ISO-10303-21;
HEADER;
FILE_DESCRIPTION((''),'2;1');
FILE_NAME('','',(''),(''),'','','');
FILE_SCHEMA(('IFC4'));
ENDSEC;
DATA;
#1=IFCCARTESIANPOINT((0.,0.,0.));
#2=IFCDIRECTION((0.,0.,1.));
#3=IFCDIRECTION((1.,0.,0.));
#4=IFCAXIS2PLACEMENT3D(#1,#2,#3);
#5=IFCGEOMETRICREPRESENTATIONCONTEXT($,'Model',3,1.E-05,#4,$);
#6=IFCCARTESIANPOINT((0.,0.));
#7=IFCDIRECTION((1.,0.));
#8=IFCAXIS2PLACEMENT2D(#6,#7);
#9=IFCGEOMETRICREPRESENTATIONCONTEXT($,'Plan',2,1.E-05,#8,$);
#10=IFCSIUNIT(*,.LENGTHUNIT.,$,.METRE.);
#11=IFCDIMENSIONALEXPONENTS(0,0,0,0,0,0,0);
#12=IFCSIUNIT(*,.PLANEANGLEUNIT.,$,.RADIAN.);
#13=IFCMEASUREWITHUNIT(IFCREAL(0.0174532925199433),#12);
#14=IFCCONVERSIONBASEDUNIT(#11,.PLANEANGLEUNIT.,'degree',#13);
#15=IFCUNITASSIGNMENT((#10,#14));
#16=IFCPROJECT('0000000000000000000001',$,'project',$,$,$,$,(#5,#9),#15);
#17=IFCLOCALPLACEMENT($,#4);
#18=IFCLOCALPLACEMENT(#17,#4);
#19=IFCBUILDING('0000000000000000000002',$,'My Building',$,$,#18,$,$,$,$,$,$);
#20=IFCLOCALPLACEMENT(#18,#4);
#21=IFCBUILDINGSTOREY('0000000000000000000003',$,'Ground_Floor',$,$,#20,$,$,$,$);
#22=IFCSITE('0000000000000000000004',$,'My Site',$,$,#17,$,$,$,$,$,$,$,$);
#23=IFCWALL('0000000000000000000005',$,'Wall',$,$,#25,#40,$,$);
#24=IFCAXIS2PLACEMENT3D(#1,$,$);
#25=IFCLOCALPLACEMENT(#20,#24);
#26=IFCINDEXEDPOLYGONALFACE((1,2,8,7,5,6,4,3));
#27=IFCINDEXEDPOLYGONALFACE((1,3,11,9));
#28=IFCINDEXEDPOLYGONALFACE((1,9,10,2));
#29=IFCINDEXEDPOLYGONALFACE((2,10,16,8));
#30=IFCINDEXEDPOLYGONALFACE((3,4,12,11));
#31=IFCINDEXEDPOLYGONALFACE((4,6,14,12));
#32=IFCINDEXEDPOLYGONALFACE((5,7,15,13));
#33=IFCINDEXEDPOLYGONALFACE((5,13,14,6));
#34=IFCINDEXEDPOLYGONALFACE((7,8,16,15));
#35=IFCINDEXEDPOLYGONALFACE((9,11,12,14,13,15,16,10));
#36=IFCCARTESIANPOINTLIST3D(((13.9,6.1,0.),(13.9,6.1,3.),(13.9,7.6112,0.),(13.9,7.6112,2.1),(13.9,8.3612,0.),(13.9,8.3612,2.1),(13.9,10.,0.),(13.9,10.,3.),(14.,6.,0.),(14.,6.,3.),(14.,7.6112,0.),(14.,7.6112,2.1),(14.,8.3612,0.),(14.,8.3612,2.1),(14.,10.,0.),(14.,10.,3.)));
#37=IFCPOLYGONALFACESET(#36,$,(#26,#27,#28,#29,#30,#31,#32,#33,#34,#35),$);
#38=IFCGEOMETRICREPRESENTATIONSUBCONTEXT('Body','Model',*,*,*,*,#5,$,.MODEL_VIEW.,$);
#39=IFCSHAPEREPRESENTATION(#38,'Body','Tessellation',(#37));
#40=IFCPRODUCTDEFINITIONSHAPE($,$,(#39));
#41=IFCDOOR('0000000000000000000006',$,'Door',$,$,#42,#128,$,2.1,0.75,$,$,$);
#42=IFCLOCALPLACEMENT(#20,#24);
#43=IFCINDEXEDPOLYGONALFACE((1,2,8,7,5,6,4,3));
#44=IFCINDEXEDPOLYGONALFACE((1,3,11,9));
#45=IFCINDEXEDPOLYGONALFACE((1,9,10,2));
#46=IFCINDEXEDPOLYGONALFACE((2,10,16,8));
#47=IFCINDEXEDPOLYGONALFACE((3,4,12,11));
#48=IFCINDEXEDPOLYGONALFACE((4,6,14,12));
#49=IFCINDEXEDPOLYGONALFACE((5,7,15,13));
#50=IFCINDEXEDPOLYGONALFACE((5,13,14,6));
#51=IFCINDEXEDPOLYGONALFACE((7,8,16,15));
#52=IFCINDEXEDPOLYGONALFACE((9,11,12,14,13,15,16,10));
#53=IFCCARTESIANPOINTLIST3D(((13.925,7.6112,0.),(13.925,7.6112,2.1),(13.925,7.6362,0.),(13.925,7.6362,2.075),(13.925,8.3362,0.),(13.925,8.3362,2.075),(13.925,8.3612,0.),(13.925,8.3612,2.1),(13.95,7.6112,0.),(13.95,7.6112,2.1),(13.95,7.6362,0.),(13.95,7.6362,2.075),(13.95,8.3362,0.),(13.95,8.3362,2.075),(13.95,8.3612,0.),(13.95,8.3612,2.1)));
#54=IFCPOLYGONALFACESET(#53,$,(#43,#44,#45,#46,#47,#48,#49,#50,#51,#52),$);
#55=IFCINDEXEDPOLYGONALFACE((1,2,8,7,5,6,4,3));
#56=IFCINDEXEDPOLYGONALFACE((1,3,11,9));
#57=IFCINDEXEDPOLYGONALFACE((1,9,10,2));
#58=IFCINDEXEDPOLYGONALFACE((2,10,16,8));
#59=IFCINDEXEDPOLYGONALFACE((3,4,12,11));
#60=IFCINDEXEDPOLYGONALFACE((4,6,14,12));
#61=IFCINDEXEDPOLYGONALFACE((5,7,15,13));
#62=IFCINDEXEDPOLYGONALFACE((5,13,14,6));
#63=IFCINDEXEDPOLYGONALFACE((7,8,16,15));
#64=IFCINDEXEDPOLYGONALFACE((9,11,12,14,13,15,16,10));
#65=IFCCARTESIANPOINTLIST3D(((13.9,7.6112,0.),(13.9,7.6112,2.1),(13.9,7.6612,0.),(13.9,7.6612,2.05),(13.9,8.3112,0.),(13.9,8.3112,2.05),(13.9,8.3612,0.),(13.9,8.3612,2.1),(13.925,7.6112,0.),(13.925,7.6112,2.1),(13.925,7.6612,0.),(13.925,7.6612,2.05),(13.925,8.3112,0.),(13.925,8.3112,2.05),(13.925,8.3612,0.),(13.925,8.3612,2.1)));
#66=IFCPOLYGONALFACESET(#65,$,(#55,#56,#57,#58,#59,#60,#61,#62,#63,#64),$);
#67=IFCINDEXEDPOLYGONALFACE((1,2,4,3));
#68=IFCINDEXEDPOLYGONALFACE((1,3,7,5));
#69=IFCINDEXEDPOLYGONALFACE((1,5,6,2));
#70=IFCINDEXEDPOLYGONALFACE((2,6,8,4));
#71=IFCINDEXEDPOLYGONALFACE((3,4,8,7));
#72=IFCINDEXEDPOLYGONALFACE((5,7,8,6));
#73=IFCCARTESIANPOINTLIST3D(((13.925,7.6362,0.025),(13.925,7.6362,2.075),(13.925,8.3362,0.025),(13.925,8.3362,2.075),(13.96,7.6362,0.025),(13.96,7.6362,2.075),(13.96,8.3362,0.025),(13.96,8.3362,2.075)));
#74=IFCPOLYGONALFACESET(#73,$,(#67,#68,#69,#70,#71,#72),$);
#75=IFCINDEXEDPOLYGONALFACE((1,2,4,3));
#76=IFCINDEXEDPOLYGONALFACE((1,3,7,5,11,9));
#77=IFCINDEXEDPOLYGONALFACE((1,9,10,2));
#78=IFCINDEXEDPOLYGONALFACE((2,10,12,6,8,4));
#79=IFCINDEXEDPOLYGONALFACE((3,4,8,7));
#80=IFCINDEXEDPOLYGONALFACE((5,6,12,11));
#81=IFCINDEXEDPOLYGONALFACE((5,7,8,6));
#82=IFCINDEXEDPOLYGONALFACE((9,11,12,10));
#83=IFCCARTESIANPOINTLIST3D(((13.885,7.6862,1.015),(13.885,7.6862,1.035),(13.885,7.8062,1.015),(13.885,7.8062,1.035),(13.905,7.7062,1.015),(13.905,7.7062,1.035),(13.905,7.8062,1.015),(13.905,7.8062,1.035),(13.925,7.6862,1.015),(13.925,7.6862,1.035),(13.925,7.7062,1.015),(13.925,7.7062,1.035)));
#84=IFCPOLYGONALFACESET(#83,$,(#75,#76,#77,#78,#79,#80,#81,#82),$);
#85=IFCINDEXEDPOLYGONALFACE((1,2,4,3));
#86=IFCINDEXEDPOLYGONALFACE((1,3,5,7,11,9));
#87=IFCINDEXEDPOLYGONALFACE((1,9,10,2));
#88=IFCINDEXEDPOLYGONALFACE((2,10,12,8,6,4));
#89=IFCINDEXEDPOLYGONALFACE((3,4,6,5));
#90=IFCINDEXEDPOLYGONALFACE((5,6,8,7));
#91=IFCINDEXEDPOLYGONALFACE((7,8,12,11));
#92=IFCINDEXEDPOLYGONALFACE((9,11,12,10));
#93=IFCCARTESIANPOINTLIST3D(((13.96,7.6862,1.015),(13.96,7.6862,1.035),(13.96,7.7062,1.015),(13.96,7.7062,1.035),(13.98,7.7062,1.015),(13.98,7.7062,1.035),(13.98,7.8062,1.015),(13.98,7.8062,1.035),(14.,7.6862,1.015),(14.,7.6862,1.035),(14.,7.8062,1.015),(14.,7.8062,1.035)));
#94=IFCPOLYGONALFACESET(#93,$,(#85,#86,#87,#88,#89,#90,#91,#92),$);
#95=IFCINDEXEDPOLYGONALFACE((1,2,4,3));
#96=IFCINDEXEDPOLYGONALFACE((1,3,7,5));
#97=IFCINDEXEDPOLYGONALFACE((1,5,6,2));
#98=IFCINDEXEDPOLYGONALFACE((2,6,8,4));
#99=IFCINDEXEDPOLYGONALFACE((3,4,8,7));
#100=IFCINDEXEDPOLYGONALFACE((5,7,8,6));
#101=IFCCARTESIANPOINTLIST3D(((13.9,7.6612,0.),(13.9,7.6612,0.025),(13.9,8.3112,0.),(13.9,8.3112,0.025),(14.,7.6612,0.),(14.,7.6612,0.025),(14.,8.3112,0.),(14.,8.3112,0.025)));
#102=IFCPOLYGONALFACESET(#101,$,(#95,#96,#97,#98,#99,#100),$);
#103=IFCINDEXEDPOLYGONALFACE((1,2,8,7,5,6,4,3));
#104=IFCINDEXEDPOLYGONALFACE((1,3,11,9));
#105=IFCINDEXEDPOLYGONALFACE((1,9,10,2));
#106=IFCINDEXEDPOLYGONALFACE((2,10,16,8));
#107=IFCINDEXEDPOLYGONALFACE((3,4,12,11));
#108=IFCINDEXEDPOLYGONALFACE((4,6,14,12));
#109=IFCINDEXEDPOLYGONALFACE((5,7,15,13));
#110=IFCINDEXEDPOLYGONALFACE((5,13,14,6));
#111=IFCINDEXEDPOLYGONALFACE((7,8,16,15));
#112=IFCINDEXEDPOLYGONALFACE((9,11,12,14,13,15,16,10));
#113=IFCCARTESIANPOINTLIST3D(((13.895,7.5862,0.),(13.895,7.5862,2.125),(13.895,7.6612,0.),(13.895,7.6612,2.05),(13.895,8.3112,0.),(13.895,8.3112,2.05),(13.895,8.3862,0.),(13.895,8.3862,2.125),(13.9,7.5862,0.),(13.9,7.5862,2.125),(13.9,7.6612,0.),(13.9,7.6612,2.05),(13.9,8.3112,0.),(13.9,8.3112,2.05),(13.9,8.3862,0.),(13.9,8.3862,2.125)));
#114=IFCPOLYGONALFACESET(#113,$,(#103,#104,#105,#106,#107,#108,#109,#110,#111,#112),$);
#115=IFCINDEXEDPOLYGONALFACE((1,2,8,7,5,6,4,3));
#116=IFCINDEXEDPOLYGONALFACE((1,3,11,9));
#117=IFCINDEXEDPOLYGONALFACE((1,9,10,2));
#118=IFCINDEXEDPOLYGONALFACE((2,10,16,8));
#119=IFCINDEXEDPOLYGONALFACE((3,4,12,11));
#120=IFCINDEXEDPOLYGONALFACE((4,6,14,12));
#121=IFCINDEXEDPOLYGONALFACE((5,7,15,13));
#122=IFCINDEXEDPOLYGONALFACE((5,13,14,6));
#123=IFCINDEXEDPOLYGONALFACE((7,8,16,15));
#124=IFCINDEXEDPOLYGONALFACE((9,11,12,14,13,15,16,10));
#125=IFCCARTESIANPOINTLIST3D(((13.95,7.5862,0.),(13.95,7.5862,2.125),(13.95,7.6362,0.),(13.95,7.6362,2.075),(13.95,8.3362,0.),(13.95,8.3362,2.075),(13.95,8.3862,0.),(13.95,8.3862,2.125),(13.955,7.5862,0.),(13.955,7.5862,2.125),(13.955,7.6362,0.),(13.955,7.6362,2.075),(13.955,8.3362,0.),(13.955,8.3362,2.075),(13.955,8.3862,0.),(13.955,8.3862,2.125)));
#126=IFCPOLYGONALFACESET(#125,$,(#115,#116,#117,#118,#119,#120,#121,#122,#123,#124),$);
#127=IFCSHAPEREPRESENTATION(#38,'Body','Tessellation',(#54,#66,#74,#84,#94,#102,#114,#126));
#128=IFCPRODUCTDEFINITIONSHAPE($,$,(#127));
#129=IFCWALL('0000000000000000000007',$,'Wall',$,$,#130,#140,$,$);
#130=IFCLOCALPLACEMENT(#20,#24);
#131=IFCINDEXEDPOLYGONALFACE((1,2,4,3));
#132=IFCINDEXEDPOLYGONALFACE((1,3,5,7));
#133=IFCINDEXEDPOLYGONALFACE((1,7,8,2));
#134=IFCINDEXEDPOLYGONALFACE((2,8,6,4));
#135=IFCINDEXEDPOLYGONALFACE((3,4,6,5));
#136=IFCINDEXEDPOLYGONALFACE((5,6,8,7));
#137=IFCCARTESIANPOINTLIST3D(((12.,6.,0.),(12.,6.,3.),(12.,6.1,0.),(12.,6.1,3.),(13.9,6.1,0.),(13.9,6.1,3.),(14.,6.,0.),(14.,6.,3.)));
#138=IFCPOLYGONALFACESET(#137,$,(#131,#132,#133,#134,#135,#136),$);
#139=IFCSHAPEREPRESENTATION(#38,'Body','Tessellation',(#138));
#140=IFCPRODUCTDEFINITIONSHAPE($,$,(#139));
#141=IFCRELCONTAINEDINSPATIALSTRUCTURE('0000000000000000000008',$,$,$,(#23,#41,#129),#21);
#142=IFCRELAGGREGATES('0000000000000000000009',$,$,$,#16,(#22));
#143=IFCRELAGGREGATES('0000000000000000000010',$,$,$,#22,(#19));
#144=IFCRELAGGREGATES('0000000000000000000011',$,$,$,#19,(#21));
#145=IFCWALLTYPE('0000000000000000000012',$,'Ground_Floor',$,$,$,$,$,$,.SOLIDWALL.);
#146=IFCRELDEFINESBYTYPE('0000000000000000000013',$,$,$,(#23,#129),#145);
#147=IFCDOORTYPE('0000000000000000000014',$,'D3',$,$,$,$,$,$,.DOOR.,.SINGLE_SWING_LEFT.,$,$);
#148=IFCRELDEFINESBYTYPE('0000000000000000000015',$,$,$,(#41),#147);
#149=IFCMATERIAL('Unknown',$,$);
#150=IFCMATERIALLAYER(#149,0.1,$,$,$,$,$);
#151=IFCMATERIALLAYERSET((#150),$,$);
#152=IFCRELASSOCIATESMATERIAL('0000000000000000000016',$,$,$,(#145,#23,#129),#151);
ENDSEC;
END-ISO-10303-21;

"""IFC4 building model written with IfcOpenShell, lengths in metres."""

from ifc_helpers import new_model, entity, si_unit, converted_unit, frame, origin_with_axes, origin_2d_with_axis, place, context, subcontext, project, spatial, line, indexed_curve, outline, extrude, shape, source, transform, mapped, material, layer, layer_set, layer_usage, type_object, type_shapes, element, fill, save


model = new_model("IFC4")

# Units and contexts
model_context = context("Model", 3, precision=1e-05, world=origin_with_axes())
plan_context = context("Plan", 2, precision=1e-05, world=origin_2d_with_axis())
body_context_1 = subcontext(model_context, "Body", "Model", "MODEL_VIEW")
body_context_2 = subcontext(plan_context, "Body", "Plan", "PLAN_VIEW")
ifc_project = project(units=[si_unit("LENGTHUNIT", "METRE"), converted_unit("PLANEANGLEUNIT", "degree", entity("IfcReal", 0.0174532925199433), si_unit("PLANEANGLEUNIT", "RADIAN"), dimensions=[0, 0, 0, 0, 0, 0, 0])], contexts=[model_context, plan_context])

# Site, building, storey
site_placement = place(None, origin_with_axes())
site = spatial("IfcSite", under=ifc_project, at=site_placement, Name="My Site")
building_placement = place(site_placement, origin_with_axes())
building = spatial("IfcBuilding", under=site, at=building_placement, Name="My Building")
storey_placement = place(building_placement, origin_with_axes())
storey = spatial("IfcBuildingStorey", under=building, at=storey_placement, Name="Ground_Floor")

# Shared definitions
ifc_material = material(Name="Unknown")

# Shared definitions
ifc_layer = layer(ifc_material, 0.1)
ifc_layer_set = layer_set([ifc_layer])
wall_type = type_object("IfcWallType", Name="Ground_Floor", PredefinedType="SOLIDWALL", material=ifc_layer_set)

# Wall, opening, door
ifc_layer_usage_1 = layer_usage(ifc_layer_set, "AXIS2", "POSITIVE", 0.0)
wall_1_placement = place(storey_placement, frame((14.0, 6.0, 0.0), z_axis=(0.0, 0.0, 1.0), x_axis=(0.0, 1.0, 0.0)))
wall_1 = element("IfcWall", 1, at=wall_1_placement, inside=storey, type_object=wall_type, material=ifc_layer_usage_1, Name="Wall", context=body_context_1, shape_type="SweptSolid", body=[
    extrude(outline(indexed_curve([(0.0, 0.0), (0.1, 0.1), (4.0, 0.1), (4.0, 0.0)], segments=[line(1, 2, 3, 4, 1)])), origin_with_axes(), (0.0, 0.0, 1.0), 3.0),
])
shared_shape_1 = source(origin_with_axes(), body_context_1, "Body", "SweptSolid", [
    extrude(outline(indexed_curve([(0.0, 0.0), (0.75, 0.0), (0.75, 2.1), (0.0, 2.1)], segments=[line(1, 2, 3, 4, 1)])), frame((0.0, -0.6, 0.0), z_axis=(0.0, -1.0, 0.0), x_axis=(1.0, 0.0, 0.0)), (0.0, 0.0, -1.0), 1.2),
])
opening_1_placement = place(wall_1_placement, frame((2.3612, 0.1, 0.0), z_axis=(0.0, 0.0, 1.0), x_axis=(-1.0, 0.0, 0.0)))
opening_1 = element("IfcOpeningElement", 2, at=opening_1_placement, cuts=wall_1, PredefinedType="OPENING", context=body_context_1, shape_type="MappedRepresentation", body=[
    mapped(shared_shape_1, transform((0.0, 0.0, 0.0), x_axis=(1.0, 0.0, 0.0), y_axis=(0.0, 1.0, 0.0), z_axis=(0.0, 0.0, 1.0), scale=1.0)),
])
door_type_1 = type_object("IfcDoorType", Name="D3", OperationType="SINGLE_SWING_LEFT", PredefinedType="DOOR")
shared_shape_2 = source(origin_with_axes(), body_context_1, "Body", "SweptSolid", [
    extrude(outline(indexed_curve([(0.0, 0.0), (0.0, 2.1), (0.75, 2.1), (0.75, 0.0), (0.725, 0.0), (0.725, 2.075), (0.025, 2.075), (0.025, 0.0)], segments=[line(1, 2, 3, 4, 5, 6, 7, 8, 1)])), frame((0.0, 0.025, 0.0), z_axis=(0.0, -1.0, 0.0), x_axis=(1.0, 0.0, 0.0)), (0.0, 0.0, -1.0), 0.025),
    extrude(outline(indexed_curve([(0.0, 0.0), (0.0, 2.1), (0.75, 2.1), (0.75, 0.0), (0.7, 0.0), (0.7, 2.05), (0.05, 2.05), (0.05, 0.0)], segments=[line(1, 2, 3, 4, 5, 6, 7, 8, 1)])), frame((0.0, 0.0, 0.0), z_axis=(0.0, -1.0, 0.0), x_axis=(1.0, 0.0, 0.0)), (0.0, 0.0, -1.0), 0.025),
    extrude(outline(indexed_curve([(0.0, 0.0), (0.7, 0.0), (0.7, 0.035), (0.0, 0.035)], segments=[line(1, 2, 3, 4, 1)])), frame((0.025, 0.025, 0.025), z_axis=(0.0, 0.0, 1.0), x_axis=(1.0, 0.0, 0.0)), (0.0, 0.0, 1.0), 2.05),
    extrude(outline(indexed_curve([(0.0, 0.0), (0.0, -0.04), (-0.12, -0.04), (-0.12, -0.02), (-0.02, -0.02), (-0.02, 0.0)], segments=[line(1, 2, 3, 4, 5, 6, 1)])), frame((0.675, 0.025, 1.015), z_axis=(0.0, 0.0, 1.0), x_axis=(1.0, 0.0, 0.0)), (0.0, 0.0, 1.0), 0.02),
    extrude(outline(indexed_curve([(0.0, 0.0), (0.0, 0.04), (-0.12, 0.04), (-0.12, 0.02), (-0.02, 0.02), (-0.02, 0.0)], segments=[line(1, 2, 3, 4, 5, 6, 1)])), frame((0.675, 0.06, 1.015), z_axis=(0.0, 0.0, 1.0), x_axis=(1.0, 0.0, 0.0)), (0.0, 0.0, 1.0), 0.02),
    extrude(outline(indexed_curve([(0.0, 0.0), (0.65, 0.0), (0.65, 0.1), (0.0, 0.1)], segments=[line(1, 2, 3, 4, 1)])), frame((0.05, 0.0, 0.0), z_axis=(0.0, 0.0, 1.0), x_axis=(1.0, 0.0, 0.0)), (0.0, 0.0, 1.0), 0.025),
    extrude(outline(indexed_curve([(0.0, 0.0), (0.0, 2.125), (0.8, 2.125), (0.8, 0.0), (0.725, 0.0), (0.725, 2.05), (0.075, 2.05), (0.075, 0.0)], segments=[line(1, 2, 3, 4, 5, 6, 7, 8, 1)])), frame((-0.025, -0.005, 0.0), z_axis=(0.0, -1.0, 0.0), x_axis=(1.0, 0.0, 0.0)), (0.0, 0.0, -1.0), 0.005),
    extrude(outline(indexed_curve([(0.0, 0.0), (0.0, 2.125), (0.8, 2.125), (0.8, 0.0), (0.75, 0.0), (0.75, 2.075), (0.05, 2.075), (0.05, 0.0)], segments=[line(1, 2, 3, 4, 5, 6, 7, 8, 1)])), frame((-0.025, 0.05, 0.0), z_axis=(0.0, -1.0, 0.0), x_axis=(1.0, 0.0, 0.0)), (0.0, 0.0, -1.0), 0.005),
])
shared_shape_3 = source(origin_with_axes(), body_context_2, "Body", "Curve2D", [
    entity("IfcIndexedPolyCurve", entity("IfcCartesianPointList2D", [[0.0, 0.0], [0.0, 0.05], [0.025, 0.05], [0.025, 0.025], [0.05, 0.025], [0.05, 0.0]]), [entity("IfcLineIndex", [1, 2, 3, 4, 5, 6, 1])]),
    entity("IfcIndexedPolyCurve", entity("IfcCartesianPointList2D", [[0.75, 0.0], [0.75, 0.05], [0.725, 0.05], [0.725, 0.025], [0.7, 0.025], [0.7, 0.0]]), [entity("IfcLineIndex", [1, 2, 3, 4, 5, 6, 1])]),
    entity("IfcTrimmedCurve", entity("IfcEllipse", entity("IfcAxis2Placement2D", entity("IfcCartesianPoint", [0.06, 0.05]), entity("IfcDirection", [1.0, 0.0])), 0.665, 0.7), [entity("IfcCartesianPoint", [0.725, 0.05])], [entity("IfcCartesianPoint", [0.06, 0.75])], True, "CARTESIAN"),
    entity("IfcIndexedPolyCurve", entity("IfcCartesianPointList2D", [[0.025, 0.05], [0.06, 0.05], [0.06, 0.75], [0.025, 0.75]]), [entity("IfcLineIndex", [1, 2, 3, 4, 1])]),
])
type_shapes(door_type_1, [shared_shape_2, shared_shape_3])
door_1_placement = place(opening_1_placement, frame((0.0, 0.0, 0.0), z_axis=(0.0, 0.0, 1.0), x_axis=(1.0, 0.0, 0.0)))
door_1 = element("IfcDoor", 3, at=door_1_placement, inside=storey, type_object=door_type_1, Name="Door", OverallHeight=2.1, OverallWidth=0.75, shapes=[
    shape(body_context_1, "Body", "MappedRepresentation", [mapped(shared_shape_2, transform((0.0, 0.0, 0.0), x_axis=(1.0, 0.0, 0.0), y_axis=(0.0, 1.0, 0.0), z_axis=(0.0, 0.0, 1.0), scale=1.0))]),
    shape(body_context_2, "Body", "MappedRepresentation", [mapped(shared_shape_3, transform((0.0, 0.0, 0.0), x_axis=(1.0, 0.0, 0.0), y_axis=(0.0, 1.0, 0.0), z_axis=(0.0, 0.0, 1.0), scale=1.0))]),
])
fill(opening_1, door_1)

# Wall
ifc_layer_usage_2 = layer_usage(ifc_layer_set, "AXIS2", "POSITIVE", 0.0)
wall_2_placement = place(storey_placement, frame((12.0, 6.0, 0.0), z_axis=(0.0, 0.0, 1.0), x_axis=(1.0, 0.0, 0.0)))
element("IfcWall", 4, at=wall_2_placement, inside=storey, type_object=wall_type, material=ifc_layer_usage_2, Name="Wall", context=body_context_1, shape_type="SweptSolid", body=[
    extrude(outline(indexed_curve([(0.0, 0.0), (0.0, 0.1), (1.9, 0.1), (2.0, 0.0)], segments=[line(1, 2, 3, 4, 1)])), origin_with_axes(), (0.0, 0.0, 1.0), 3.0),
])

save(model, "model.ifc")
